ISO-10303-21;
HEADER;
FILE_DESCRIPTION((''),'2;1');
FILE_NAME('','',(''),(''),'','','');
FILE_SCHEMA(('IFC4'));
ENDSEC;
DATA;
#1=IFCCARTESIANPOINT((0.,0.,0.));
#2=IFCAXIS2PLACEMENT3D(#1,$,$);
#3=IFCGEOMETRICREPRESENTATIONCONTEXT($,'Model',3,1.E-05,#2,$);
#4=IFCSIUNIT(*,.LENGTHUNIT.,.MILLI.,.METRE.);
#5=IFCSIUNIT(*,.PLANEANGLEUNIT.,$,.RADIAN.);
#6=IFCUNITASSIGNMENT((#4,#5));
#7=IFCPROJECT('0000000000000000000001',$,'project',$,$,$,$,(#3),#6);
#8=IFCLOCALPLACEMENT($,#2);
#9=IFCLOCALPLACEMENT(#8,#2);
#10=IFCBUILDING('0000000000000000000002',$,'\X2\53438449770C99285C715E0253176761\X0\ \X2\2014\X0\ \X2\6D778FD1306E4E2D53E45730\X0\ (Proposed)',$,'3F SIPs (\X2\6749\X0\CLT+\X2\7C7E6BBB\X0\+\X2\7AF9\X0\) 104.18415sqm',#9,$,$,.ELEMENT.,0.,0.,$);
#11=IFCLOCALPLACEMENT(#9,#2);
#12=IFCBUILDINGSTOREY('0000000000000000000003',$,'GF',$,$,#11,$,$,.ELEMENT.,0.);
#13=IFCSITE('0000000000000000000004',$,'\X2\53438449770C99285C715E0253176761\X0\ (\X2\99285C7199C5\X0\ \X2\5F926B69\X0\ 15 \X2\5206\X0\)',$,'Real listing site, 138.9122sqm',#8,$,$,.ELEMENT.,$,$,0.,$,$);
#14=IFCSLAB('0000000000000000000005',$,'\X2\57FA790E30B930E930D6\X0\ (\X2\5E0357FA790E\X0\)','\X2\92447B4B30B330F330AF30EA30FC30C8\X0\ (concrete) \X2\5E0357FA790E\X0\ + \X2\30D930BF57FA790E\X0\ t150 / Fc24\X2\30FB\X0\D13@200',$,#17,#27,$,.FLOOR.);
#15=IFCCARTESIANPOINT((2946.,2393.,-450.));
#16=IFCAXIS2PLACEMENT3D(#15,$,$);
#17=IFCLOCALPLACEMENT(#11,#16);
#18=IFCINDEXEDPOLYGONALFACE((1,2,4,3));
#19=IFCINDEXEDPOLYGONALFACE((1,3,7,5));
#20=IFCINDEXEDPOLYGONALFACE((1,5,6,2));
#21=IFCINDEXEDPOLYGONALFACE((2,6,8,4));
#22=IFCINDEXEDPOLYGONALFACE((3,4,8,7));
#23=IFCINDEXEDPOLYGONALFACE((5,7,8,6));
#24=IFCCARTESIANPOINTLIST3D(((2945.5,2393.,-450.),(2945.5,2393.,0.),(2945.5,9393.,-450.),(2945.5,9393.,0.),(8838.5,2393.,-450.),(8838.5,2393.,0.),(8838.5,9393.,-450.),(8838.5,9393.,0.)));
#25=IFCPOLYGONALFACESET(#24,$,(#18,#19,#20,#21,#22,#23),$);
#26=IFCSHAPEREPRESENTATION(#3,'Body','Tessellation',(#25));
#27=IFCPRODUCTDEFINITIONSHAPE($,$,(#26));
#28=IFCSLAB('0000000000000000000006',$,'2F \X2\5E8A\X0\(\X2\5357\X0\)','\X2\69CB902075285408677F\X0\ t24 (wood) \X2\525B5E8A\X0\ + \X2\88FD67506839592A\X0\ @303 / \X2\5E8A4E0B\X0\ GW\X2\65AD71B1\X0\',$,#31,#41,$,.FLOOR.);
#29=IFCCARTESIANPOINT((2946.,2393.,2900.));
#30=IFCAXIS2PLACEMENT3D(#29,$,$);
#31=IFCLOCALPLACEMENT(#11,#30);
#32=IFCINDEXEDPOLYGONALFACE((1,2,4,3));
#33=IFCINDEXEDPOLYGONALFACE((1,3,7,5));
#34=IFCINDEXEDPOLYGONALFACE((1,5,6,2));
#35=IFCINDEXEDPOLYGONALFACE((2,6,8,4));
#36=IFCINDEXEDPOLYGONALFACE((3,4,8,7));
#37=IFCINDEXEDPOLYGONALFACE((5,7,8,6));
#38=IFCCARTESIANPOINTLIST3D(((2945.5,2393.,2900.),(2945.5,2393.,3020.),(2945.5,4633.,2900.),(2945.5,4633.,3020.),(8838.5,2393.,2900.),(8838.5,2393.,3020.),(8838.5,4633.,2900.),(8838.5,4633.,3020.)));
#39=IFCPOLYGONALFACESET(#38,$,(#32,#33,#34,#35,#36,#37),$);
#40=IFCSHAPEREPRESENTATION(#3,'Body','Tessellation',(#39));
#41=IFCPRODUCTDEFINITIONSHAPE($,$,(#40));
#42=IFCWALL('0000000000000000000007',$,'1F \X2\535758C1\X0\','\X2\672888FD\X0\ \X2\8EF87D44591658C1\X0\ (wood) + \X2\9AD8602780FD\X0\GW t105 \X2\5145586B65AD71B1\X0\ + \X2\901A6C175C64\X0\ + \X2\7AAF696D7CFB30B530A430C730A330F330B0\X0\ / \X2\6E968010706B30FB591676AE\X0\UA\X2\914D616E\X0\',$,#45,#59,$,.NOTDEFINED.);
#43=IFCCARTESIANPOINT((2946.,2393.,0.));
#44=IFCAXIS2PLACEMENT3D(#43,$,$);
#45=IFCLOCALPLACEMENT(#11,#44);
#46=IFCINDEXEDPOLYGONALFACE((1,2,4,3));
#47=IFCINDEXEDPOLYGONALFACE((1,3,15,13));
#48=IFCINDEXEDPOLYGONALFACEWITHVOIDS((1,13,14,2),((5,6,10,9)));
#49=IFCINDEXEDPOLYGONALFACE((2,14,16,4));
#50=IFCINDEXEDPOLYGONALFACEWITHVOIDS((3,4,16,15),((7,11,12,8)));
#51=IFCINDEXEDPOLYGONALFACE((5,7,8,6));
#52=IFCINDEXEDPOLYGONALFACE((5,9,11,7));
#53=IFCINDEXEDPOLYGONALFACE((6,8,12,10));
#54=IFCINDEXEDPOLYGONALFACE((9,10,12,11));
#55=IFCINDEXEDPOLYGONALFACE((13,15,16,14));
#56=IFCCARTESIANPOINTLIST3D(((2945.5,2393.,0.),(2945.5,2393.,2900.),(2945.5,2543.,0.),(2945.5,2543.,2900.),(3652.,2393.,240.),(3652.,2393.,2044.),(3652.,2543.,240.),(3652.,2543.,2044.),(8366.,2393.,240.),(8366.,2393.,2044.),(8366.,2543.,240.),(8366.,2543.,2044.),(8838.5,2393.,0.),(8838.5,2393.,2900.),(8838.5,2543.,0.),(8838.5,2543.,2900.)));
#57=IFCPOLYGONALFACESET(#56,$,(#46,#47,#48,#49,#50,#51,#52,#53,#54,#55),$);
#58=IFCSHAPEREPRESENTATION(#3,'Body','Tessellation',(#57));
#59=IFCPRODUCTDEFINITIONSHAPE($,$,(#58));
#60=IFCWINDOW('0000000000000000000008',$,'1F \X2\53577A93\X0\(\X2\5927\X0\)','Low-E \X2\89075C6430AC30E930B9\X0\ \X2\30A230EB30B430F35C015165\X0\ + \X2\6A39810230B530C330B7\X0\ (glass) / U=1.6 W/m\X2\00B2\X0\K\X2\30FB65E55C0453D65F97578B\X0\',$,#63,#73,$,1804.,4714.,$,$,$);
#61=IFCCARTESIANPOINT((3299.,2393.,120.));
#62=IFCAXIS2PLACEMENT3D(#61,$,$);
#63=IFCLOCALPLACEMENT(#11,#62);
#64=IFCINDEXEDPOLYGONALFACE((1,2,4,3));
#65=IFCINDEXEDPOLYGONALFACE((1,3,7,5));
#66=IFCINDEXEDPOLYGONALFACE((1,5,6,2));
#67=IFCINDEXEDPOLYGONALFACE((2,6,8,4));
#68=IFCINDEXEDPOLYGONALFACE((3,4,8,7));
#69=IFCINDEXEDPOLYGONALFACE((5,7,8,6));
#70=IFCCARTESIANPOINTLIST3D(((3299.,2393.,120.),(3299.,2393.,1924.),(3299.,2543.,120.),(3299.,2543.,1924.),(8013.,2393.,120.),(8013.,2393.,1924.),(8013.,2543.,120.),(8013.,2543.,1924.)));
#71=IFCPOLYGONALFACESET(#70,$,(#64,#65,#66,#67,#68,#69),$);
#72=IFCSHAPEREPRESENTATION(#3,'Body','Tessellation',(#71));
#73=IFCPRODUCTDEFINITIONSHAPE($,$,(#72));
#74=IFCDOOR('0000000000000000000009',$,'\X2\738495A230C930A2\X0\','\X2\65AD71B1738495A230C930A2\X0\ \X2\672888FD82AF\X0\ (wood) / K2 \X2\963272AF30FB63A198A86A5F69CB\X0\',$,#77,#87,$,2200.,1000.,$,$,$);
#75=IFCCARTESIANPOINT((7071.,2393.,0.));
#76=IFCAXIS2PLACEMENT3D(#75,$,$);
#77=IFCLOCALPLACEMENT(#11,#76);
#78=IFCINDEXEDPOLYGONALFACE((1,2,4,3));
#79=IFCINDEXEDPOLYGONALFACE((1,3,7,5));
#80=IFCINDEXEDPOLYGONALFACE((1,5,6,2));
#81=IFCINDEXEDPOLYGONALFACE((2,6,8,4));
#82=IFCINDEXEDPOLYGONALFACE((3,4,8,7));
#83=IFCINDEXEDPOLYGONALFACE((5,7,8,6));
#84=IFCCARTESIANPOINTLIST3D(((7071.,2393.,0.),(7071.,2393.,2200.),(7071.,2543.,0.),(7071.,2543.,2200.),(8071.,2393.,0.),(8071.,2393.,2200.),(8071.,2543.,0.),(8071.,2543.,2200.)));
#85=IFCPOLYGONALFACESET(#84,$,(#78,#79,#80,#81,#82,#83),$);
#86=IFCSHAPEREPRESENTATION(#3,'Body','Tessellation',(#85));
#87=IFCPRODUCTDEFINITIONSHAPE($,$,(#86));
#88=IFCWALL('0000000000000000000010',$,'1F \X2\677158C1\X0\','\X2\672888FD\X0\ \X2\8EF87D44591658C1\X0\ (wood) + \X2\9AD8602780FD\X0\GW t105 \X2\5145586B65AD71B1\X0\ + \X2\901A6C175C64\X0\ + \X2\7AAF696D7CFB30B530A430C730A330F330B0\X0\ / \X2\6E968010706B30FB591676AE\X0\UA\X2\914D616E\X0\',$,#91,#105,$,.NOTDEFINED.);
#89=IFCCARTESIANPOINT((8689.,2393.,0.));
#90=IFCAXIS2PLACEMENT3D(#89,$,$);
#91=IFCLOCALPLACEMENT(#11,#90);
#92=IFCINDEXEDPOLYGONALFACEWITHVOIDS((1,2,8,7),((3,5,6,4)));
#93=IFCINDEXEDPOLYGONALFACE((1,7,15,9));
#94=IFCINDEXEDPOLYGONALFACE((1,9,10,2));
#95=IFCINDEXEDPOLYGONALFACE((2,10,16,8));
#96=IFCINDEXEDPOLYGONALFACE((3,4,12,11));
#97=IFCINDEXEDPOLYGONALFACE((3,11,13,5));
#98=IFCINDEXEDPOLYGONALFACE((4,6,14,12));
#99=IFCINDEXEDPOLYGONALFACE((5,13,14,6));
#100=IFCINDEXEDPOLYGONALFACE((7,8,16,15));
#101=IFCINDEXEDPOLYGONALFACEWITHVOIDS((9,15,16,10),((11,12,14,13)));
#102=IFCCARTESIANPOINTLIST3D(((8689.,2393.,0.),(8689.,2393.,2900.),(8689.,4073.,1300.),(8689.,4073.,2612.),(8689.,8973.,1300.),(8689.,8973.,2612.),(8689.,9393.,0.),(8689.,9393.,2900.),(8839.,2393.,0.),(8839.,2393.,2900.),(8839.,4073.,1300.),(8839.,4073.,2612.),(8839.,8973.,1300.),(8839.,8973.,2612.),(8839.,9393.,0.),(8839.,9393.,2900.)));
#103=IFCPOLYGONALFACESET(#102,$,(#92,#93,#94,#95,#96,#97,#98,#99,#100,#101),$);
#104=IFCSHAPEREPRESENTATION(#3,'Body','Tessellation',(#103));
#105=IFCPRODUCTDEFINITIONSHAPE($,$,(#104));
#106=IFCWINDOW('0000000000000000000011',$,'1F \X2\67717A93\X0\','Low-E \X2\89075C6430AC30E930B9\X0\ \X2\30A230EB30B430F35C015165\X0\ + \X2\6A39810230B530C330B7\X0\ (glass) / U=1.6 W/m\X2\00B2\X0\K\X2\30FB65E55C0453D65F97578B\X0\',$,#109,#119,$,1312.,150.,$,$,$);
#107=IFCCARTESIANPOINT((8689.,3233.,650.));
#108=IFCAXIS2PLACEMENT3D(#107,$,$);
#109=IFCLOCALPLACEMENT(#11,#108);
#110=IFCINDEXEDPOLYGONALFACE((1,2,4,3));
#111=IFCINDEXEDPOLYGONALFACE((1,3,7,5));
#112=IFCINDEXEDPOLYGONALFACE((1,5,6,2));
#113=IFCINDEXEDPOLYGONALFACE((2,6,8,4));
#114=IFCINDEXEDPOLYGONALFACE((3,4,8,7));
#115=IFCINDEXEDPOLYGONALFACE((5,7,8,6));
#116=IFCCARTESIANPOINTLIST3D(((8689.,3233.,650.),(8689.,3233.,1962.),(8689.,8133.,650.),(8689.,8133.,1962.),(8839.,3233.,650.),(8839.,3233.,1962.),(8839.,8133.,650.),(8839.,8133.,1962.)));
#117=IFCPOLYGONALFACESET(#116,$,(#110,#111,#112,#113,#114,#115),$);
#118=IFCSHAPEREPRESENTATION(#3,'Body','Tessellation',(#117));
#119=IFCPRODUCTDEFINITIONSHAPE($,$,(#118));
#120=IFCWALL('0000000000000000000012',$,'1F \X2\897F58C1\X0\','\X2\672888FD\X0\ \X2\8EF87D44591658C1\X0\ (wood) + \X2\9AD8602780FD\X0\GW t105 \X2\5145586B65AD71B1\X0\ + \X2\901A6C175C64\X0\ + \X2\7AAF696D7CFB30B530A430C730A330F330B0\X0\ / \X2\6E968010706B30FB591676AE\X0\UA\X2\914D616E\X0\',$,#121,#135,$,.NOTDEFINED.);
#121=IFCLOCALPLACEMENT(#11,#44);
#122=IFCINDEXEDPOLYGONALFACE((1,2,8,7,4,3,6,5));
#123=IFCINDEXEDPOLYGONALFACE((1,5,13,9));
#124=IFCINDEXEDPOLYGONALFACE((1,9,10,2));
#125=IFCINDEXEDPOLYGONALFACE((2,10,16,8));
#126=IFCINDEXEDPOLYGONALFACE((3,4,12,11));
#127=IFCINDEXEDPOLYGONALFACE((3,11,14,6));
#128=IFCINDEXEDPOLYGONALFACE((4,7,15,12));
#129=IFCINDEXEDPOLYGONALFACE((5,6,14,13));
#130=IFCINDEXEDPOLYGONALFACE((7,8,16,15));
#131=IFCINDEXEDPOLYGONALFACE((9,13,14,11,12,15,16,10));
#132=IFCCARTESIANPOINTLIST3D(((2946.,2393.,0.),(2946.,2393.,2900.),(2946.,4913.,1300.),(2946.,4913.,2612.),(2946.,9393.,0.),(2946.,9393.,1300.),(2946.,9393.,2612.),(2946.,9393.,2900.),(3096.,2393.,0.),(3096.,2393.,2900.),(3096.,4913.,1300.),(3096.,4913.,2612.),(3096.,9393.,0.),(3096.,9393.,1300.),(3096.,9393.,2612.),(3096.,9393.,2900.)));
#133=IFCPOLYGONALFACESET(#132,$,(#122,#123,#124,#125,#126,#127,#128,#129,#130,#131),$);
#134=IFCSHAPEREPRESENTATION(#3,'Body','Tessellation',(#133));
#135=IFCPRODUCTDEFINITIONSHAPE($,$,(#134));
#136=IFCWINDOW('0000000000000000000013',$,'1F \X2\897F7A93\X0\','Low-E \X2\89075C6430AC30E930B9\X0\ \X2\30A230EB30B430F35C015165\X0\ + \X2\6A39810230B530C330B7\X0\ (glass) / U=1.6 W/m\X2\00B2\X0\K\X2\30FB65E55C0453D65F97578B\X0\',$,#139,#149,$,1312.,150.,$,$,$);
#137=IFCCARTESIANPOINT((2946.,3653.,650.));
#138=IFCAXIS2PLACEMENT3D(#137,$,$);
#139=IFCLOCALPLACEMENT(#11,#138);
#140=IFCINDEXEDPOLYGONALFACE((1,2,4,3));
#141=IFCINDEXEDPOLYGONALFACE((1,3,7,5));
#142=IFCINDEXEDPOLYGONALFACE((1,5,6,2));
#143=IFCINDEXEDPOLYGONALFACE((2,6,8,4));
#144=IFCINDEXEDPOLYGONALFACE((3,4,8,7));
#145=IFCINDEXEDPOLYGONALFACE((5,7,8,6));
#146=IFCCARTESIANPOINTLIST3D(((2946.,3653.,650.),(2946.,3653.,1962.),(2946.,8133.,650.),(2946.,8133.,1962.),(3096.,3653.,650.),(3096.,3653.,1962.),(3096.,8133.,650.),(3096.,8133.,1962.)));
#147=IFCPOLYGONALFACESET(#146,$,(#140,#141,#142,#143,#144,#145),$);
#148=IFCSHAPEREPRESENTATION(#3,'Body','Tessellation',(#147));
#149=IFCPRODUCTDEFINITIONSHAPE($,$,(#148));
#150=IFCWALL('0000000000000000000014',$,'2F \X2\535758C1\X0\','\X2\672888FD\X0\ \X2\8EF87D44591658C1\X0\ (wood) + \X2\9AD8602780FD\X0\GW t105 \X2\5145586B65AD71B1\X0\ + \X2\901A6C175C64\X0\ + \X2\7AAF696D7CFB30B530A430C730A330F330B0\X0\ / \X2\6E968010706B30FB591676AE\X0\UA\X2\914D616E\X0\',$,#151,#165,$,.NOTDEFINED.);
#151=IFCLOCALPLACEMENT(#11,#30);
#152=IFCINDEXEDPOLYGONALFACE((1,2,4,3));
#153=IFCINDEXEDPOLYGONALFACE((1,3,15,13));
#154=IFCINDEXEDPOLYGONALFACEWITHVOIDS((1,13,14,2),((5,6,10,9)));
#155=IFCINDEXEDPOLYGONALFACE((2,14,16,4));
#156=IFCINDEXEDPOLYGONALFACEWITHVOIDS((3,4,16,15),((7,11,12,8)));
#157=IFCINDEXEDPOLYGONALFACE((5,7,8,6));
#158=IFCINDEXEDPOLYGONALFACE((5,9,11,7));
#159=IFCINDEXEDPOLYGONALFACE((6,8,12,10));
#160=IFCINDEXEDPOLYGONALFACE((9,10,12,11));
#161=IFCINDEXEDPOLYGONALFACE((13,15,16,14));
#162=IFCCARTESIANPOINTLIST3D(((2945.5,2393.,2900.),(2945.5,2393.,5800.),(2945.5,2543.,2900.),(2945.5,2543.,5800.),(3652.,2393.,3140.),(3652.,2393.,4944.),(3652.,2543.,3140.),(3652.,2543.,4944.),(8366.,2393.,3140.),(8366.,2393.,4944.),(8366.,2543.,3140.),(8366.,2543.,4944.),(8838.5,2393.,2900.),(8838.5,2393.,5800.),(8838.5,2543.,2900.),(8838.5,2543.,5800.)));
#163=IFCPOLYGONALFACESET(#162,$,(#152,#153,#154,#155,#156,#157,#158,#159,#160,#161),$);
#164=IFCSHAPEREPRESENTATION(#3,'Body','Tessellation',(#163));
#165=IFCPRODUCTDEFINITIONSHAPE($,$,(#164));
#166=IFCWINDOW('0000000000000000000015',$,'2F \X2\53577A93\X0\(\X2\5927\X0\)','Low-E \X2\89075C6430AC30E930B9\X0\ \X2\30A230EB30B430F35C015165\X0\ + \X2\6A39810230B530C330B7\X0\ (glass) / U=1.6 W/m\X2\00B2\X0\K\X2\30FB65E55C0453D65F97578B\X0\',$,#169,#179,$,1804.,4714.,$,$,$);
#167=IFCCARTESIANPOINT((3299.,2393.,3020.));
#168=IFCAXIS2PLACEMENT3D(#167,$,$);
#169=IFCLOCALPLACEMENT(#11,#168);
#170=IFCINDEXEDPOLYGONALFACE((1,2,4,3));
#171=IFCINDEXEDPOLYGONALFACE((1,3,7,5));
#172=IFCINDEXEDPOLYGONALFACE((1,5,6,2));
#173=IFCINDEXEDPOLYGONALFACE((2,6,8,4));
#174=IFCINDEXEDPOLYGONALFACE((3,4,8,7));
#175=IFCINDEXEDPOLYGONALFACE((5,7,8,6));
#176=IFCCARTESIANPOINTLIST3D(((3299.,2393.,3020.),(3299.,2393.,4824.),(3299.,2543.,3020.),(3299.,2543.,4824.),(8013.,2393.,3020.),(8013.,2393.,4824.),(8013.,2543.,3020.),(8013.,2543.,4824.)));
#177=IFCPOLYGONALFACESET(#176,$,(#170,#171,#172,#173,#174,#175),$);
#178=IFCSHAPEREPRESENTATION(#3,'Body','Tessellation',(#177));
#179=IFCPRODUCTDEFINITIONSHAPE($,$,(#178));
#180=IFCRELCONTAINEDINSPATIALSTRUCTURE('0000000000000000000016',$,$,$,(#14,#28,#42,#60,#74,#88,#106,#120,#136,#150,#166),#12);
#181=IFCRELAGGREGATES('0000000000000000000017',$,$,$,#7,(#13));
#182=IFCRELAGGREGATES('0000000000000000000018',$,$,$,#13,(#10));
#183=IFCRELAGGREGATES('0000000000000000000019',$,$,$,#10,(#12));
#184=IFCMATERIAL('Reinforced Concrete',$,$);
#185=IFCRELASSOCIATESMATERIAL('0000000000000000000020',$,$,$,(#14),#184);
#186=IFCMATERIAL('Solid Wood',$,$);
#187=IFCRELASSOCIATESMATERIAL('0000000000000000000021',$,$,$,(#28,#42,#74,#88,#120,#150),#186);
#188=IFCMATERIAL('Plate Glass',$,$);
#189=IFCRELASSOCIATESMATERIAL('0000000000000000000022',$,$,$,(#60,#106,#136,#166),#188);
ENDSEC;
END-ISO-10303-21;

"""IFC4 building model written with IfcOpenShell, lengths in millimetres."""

from ifc_helpers import new_model, si_unit, frame, frame_2d, origin, place, context, project, spatial, rectangle, extrude, material, element, fill, save


model = new_model("IFC4")

# Units and contexts
model_context = context("Model", 3, precision=1e-05, world=origin())
ifc_project = project(units=[si_unit("LENGTHUNIT", "METRE", prefix="MILLI"), si_unit("PLANEANGLEUNIT", "RADIAN")], contexts=[model_context])

# Site, building, storey
site_placement = place(None, origin())
site = spatial("IfcSite", under=ifc_project, at=site_placement, Name="千葉県館山市北条 (館山駅 徒歩 15 分)", ObjectType="Real listing site, 138.9122sqm", CompositionType="ELEMENT", RefElevation=0.0)
building_placement = place(site_placement, origin())
building = spatial("IfcBuilding", under=site, at=building_placement, Name="千葉県館山市北条 — 海近の中古地 (Proposed)", ObjectType="3F SIPs (杉CLT+籾殻+竹) 104.18415sqm", CompositionType="ELEMENT", ElevationOfRefHeight=0.0, ElevationOfTerrain=0.0)
storey_placement = place(building_placement, origin())
storey = spatial("IfcBuildingStorey", under=building, at=storey_placement, Name="GF", CompositionType="ELEMENT", Elevation=0.0)

# Slabs
ifc_material_1 = material(Name="Reinforced Concrete")
slab_1_placement = place(storey_placement, frame((2946.0, 2393.0, -450.0)))
element("IfcSlab", 1, at=slab_1_placement, inside=storey, material=ifc_material_1, Name="基礎スラブ (布基礎)", Description="鉄筋コンクリート (concrete) 布基礎 + ベタ基礎 t150 / Fc24・D13@200", PredefinedType="FLOOR", context=model_context, shape_type="SweptSolid", body=[
    extrude(rectangle(XDim=5893.0, YDim=7000.0, at=frame_2d((2946.0, 3500.0))), frame((2946.0, 2393.0, -450.0)), (0.0, 0.0, 1.0), 450.0),
])
ifc_material_2 = material(Name="Solid Wood")
slab_2_placement = place(storey_placement, frame((2946.0, 2393.0, 2900.0)))
element("IfcSlab", 2, at=slab_2_placement, inside=storey, material=ifc_material_2, Name="2F 床(南)", Description="構造用合板 t24 (wood) 剛床 + 製材根太 @303 / 床下 GW断熱", PredefinedType="FLOOR", context=model_context, shape_type="SweptSolid", body=[
    extrude(rectangle(XDim=5893.0, YDim=2240.0, at=frame_2d((2946.0, 1120.0))), frame((2946.0, 2393.0, 2900.0)), (0.0, 0.0, 1.0), 120.0),
])

# Wall, openings, window, door
wall_1_placement = place(storey_placement, frame((2946.0, 2393.0, 0.0)))
wall_1 = element("IfcWall", 3, at=wall_1_placement, inside=storey, material=ifc_material_2, Name="1F 南壁", Description="木製 軸組外壁 (wood) + 高性能GW t105 充填断熱 + 通気層 + 窯業系サイディング / 準耐火・外皮UA配慮", PredefinedType="NOTDEFINED", context=model_context, shape_type="SweptSolid", body=[
    extrude(rectangle(XDim=5893.0, YDim=150.0, at=frame_2d((2946.0, 75.0))), frame((2946.0, 2393.0, 0.0)), (0.0, 0.0, 1.0), 2900.0),
])
opening_1_placement = place(storey_placement, frame((3299.0, 2393.0, 120.0)))
opening_1 = element("IfcOpeningElement", 4, at=opening_1_placement, cuts=wall_1, PredefinedType="NOTDEFINED", context=model_context, shape_type="SweptSolid", body=[
    extrude(rectangle(XDim=4714.0, YDim=150.0, at=frame_2d((2357.0, 75.0))), frame((3299.0, 2393.0, 120.0)), (0.0, 0.0, 1.0), 1804.0),
])
opening_2_placement = place(storey_placement, frame((7071.0, 2393.0, 0.0)))
opening_2 = element("IfcOpeningElement", 5, at=opening_2_placement, cuts=wall_1, PredefinedType="NOTDEFINED", context=model_context, shape_type="SweptSolid", body=[
    extrude(rectangle(XDim=1000.0, YDim=150.0, at=frame_2d((500.0, 75.0))), frame((7071.0, 2393.0, 0.0)), (0.0, 0.0, 1.0), 2200.0),
])
ifc_material_3 = material(Name="Plate Glass")
window_1_placement = place(storey_placement, frame((3299.0, 2393.0, 120.0)))
window_1 = element("IfcWindow", 6, at=window_1_placement, inside=storey, material=ifc_material_3, Name="1F 南窓(大)", Description="Low-E 複層ガラス アルゴン封入 + 樹脂サッシ (glass) / U=1.6 W/m²K・日射取得型", OverallHeight=1804.0, OverallWidth=4714.0, context=model_context, shape_type="SweptSolid", body=[
    extrude(rectangle(XDim=4714.0, YDim=150.0, at=frame_2d((2357.0, 75.0))), frame((3299.0, 2393.0, 120.0)), (0.0, 0.0, 1.0), 1804.0),
])
fill(opening_1, window_1)
door_placement = place(storey_placement, frame((7071.0, 2393.0, 0.0)))
door = element("IfcDoor", 7, at=door_placement, inside=storey, material=ifc_material_2, Name="玄関ドア", Description="断熱玄関ドア 木製芯 (wood) / K2 防犯・採風機構", OverallHeight=2200.0, OverallWidth=1000.0, context=model_context, shape_type="SweptSolid", body=[
    extrude(rectangle(XDim=1000.0, YDim=150.0, at=frame_2d((500.0, 75.0))), frame((7071.0, 2393.0, 0.0)), (0.0, 0.0, 1.0), 2200.0),
])
fill(opening_2, door)

# Walls, openings, windows
wall_2_placement = place(storey_placement, frame((8689.0, 2393.0, 0.0)))
wall_2 = element("IfcWall", 8, at=wall_2_placement, inside=storey, material=ifc_material_2, Name="1F 東壁", Description="木製 軸組外壁 (wood) + 高性能GW t105 充填断熱 + 通気層 + 窯業系サイディング / 準耐火・外皮UA配慮", PredefinedType="NOTDEFINED", context=model_context, shape_type="SweptSolid", body=[
    extrude(rectangle(XDim=150.0, YDim=7000.0, at=frame_2d((75.0, 3500.0))), frame((8689.0, 2393.0, 0.0)), (0.0, 0.0, 1.0), 2900.0),
])
opening_3_placement = place(storey_placement, frame((8689.0, 3233.0, 650.0)))
opening_3 = element("IfcOpeningElement", 9, at=opening_3_placement, cuts=wall_2, PredefinedType="NOTDEFINED", context=model_context, shape_type="SweptSolid", body=[
    extrude(rectangle(XDim=150.0, YDim=4900.0, at=frame_2d((75.0, 2450.0))), frame((8689.0, 3233.0, 650.0)), (0.0, 0.0, 1.0), 1312.0),
])
window_2_placement = place(storey_placement, frame((8689.0, 3233.0, 650.0)))
window_2 = element("IfcWindow", 10, at=window_2_placement, inside=storey, material=ifc_material_3, Name="1F 東窓", Description="Low-E 複層ガラス アルゴン封入 + 樹脂サッシ (glass) / U=1.6 W/m²K・日射取得型", OverallHeight=1312.0, OverallWidth=150.0, context=model_context, shape_type="SweptSolid", body=[
    extrude(rectangle(XDim=150.0, YDim=4900.0, at=frame_2d((75.0, 2450.0))), frame((8689.0, 3233.0, 650.0)), (0.0, 0.0, 1.0), 1312.0),
])
fill(opening_3, window_2)
wall_3_placement = place(storey_placement, frame((2946.0, 2393.0, 0.0)))
wall_3 = element("IfcWall", 11, at=wall_3_placement, inside=storey, material=ifc_material_2, Name="1F 西壁", Description="木製 軸組外壁 (wood) + 高性能GW t105 充填断熱 + 通気層 + 窯業系サイディング / 準耐火・外皮UA配慮", PredefinedType="NOTDEFINED", context=model_context, shape_type="SweptSolid", body=[
    extrude(rectangle(XDim=150.0, YDim=7000.0, at=frame_2d((75.0, 3500.0))), frame((2946.0, 2393.0, 0.0)), (0.0, 0.0, 1.0), 2900.0),
])
opening_4_placement = place(storey_placement, frame((2946.0, 3653.0, 650.0)))
opening_4 = element("IfcOpeningElement", 12, at=opening_4_placement, cuts=wall_3, PredefinedType="NOTDEFINED", context=model_context, shape_type="SweptSolid", body=[
    extrude(rectangle(XDim=150.0, YDim=4480.0, at=frame_2d((75.0, 2240.0))), frame((2946.0, 3653.0, 650.0)), (0.0, 0.0, 1.0), 1312.0),
])
window_3_placement = place(storey_placement, frame((2946.0, 3653.0, 650.0)))
window_3 = element("IfcWindow", 13, at=window_3_placement, inside=storey, material=ifc_material_3, Name="1F 西窓", Description="Low-E 複層ガラス アルゴン封入 + 樹脂サッシ (glass) / U=1.6 W/m²K・日射取得型", OverallHeight=1312.0, OverallWidth=150.0, context=model_context, shape_type="SweptSolid", body=[
    extrude(rectangle(XDim=150.0, YDim=4480.0, at=frame_2d((75.0, 2240.0))), frame((2946.0, 3653.0, 650.0)), (0.0, 0.0, 1.0), 1312.0),
])
fill(opening_4, window_3)

# Wall, opening, window
wall_4_placement = place(storey_placement, frame((2946.0, 2393.0, 2900.0)))
wall_4 = element("IfcWall", 14, at=wall_4_placement, inside=storey, material=ifc_material_2, Name="2F 南壁", Description="木製 軸組外壁 (wood) + 高性能GW t105 充填断熱 + 通気層 + 窯業系サイディング / 準耐火・外皮UA配慮", PredefinedType="NOTDEFINED", context=model_context, shape_type="SweptSolid", body=[
    extrude(rectangle(XDim=5893.0, YDim=150.0, at=frame_2d((2946.0, 75.0))), frame((2946.0, 2393.0, 2900.0)), (0.0, 0.0, 1.0), 2900.0),
])
opening_5_placement = place(storey_placement, frame((3299.0, 2393.0, 3020.0)))
opening_5 = element("IfcOpeningElement", 15, at=opening_5_placement, cuts=wall_4, PredefinedType="NOTDEFINED", context=model_context, shape_type="SweptSolid", body=[
    extrude(rectangle(XDim=4714.0, YDim=150.0, at=frame_2d((2357.0, 75.0))), frame((3299.0, 2393.0, 3020.0)), (0.0, 0.0, 1.0), 1804.0),
])
window_4_placement = place(storey_placement, frame((3299.0, 2393.0, 3020.0)))
window_4 = element("IfcWindow", 16, at=window_4_placement, inside=storey, material=ifc_material_3, Name="2F 南窓(大)", Description="Low-E 複層ガラス アルゴン封入 + 樹脂サッシ (glass) / U=1.6 W/m²K・日射取得型", OverallHeight=1804.0, OverallWidth=4714.0, context=model_context, shape_type="SweptSolid", body=[
    extrude(rectangle(XDim=4714.0, YDim=150.0, at=frame_2d((2357.0, 75.0))), frame((3299.0, 2393.0, 3020.0)), (0.0, 0.0, 1.0), 1804.0),
])
fill(opening_5, window_4)

save(model, "model.ifc")
